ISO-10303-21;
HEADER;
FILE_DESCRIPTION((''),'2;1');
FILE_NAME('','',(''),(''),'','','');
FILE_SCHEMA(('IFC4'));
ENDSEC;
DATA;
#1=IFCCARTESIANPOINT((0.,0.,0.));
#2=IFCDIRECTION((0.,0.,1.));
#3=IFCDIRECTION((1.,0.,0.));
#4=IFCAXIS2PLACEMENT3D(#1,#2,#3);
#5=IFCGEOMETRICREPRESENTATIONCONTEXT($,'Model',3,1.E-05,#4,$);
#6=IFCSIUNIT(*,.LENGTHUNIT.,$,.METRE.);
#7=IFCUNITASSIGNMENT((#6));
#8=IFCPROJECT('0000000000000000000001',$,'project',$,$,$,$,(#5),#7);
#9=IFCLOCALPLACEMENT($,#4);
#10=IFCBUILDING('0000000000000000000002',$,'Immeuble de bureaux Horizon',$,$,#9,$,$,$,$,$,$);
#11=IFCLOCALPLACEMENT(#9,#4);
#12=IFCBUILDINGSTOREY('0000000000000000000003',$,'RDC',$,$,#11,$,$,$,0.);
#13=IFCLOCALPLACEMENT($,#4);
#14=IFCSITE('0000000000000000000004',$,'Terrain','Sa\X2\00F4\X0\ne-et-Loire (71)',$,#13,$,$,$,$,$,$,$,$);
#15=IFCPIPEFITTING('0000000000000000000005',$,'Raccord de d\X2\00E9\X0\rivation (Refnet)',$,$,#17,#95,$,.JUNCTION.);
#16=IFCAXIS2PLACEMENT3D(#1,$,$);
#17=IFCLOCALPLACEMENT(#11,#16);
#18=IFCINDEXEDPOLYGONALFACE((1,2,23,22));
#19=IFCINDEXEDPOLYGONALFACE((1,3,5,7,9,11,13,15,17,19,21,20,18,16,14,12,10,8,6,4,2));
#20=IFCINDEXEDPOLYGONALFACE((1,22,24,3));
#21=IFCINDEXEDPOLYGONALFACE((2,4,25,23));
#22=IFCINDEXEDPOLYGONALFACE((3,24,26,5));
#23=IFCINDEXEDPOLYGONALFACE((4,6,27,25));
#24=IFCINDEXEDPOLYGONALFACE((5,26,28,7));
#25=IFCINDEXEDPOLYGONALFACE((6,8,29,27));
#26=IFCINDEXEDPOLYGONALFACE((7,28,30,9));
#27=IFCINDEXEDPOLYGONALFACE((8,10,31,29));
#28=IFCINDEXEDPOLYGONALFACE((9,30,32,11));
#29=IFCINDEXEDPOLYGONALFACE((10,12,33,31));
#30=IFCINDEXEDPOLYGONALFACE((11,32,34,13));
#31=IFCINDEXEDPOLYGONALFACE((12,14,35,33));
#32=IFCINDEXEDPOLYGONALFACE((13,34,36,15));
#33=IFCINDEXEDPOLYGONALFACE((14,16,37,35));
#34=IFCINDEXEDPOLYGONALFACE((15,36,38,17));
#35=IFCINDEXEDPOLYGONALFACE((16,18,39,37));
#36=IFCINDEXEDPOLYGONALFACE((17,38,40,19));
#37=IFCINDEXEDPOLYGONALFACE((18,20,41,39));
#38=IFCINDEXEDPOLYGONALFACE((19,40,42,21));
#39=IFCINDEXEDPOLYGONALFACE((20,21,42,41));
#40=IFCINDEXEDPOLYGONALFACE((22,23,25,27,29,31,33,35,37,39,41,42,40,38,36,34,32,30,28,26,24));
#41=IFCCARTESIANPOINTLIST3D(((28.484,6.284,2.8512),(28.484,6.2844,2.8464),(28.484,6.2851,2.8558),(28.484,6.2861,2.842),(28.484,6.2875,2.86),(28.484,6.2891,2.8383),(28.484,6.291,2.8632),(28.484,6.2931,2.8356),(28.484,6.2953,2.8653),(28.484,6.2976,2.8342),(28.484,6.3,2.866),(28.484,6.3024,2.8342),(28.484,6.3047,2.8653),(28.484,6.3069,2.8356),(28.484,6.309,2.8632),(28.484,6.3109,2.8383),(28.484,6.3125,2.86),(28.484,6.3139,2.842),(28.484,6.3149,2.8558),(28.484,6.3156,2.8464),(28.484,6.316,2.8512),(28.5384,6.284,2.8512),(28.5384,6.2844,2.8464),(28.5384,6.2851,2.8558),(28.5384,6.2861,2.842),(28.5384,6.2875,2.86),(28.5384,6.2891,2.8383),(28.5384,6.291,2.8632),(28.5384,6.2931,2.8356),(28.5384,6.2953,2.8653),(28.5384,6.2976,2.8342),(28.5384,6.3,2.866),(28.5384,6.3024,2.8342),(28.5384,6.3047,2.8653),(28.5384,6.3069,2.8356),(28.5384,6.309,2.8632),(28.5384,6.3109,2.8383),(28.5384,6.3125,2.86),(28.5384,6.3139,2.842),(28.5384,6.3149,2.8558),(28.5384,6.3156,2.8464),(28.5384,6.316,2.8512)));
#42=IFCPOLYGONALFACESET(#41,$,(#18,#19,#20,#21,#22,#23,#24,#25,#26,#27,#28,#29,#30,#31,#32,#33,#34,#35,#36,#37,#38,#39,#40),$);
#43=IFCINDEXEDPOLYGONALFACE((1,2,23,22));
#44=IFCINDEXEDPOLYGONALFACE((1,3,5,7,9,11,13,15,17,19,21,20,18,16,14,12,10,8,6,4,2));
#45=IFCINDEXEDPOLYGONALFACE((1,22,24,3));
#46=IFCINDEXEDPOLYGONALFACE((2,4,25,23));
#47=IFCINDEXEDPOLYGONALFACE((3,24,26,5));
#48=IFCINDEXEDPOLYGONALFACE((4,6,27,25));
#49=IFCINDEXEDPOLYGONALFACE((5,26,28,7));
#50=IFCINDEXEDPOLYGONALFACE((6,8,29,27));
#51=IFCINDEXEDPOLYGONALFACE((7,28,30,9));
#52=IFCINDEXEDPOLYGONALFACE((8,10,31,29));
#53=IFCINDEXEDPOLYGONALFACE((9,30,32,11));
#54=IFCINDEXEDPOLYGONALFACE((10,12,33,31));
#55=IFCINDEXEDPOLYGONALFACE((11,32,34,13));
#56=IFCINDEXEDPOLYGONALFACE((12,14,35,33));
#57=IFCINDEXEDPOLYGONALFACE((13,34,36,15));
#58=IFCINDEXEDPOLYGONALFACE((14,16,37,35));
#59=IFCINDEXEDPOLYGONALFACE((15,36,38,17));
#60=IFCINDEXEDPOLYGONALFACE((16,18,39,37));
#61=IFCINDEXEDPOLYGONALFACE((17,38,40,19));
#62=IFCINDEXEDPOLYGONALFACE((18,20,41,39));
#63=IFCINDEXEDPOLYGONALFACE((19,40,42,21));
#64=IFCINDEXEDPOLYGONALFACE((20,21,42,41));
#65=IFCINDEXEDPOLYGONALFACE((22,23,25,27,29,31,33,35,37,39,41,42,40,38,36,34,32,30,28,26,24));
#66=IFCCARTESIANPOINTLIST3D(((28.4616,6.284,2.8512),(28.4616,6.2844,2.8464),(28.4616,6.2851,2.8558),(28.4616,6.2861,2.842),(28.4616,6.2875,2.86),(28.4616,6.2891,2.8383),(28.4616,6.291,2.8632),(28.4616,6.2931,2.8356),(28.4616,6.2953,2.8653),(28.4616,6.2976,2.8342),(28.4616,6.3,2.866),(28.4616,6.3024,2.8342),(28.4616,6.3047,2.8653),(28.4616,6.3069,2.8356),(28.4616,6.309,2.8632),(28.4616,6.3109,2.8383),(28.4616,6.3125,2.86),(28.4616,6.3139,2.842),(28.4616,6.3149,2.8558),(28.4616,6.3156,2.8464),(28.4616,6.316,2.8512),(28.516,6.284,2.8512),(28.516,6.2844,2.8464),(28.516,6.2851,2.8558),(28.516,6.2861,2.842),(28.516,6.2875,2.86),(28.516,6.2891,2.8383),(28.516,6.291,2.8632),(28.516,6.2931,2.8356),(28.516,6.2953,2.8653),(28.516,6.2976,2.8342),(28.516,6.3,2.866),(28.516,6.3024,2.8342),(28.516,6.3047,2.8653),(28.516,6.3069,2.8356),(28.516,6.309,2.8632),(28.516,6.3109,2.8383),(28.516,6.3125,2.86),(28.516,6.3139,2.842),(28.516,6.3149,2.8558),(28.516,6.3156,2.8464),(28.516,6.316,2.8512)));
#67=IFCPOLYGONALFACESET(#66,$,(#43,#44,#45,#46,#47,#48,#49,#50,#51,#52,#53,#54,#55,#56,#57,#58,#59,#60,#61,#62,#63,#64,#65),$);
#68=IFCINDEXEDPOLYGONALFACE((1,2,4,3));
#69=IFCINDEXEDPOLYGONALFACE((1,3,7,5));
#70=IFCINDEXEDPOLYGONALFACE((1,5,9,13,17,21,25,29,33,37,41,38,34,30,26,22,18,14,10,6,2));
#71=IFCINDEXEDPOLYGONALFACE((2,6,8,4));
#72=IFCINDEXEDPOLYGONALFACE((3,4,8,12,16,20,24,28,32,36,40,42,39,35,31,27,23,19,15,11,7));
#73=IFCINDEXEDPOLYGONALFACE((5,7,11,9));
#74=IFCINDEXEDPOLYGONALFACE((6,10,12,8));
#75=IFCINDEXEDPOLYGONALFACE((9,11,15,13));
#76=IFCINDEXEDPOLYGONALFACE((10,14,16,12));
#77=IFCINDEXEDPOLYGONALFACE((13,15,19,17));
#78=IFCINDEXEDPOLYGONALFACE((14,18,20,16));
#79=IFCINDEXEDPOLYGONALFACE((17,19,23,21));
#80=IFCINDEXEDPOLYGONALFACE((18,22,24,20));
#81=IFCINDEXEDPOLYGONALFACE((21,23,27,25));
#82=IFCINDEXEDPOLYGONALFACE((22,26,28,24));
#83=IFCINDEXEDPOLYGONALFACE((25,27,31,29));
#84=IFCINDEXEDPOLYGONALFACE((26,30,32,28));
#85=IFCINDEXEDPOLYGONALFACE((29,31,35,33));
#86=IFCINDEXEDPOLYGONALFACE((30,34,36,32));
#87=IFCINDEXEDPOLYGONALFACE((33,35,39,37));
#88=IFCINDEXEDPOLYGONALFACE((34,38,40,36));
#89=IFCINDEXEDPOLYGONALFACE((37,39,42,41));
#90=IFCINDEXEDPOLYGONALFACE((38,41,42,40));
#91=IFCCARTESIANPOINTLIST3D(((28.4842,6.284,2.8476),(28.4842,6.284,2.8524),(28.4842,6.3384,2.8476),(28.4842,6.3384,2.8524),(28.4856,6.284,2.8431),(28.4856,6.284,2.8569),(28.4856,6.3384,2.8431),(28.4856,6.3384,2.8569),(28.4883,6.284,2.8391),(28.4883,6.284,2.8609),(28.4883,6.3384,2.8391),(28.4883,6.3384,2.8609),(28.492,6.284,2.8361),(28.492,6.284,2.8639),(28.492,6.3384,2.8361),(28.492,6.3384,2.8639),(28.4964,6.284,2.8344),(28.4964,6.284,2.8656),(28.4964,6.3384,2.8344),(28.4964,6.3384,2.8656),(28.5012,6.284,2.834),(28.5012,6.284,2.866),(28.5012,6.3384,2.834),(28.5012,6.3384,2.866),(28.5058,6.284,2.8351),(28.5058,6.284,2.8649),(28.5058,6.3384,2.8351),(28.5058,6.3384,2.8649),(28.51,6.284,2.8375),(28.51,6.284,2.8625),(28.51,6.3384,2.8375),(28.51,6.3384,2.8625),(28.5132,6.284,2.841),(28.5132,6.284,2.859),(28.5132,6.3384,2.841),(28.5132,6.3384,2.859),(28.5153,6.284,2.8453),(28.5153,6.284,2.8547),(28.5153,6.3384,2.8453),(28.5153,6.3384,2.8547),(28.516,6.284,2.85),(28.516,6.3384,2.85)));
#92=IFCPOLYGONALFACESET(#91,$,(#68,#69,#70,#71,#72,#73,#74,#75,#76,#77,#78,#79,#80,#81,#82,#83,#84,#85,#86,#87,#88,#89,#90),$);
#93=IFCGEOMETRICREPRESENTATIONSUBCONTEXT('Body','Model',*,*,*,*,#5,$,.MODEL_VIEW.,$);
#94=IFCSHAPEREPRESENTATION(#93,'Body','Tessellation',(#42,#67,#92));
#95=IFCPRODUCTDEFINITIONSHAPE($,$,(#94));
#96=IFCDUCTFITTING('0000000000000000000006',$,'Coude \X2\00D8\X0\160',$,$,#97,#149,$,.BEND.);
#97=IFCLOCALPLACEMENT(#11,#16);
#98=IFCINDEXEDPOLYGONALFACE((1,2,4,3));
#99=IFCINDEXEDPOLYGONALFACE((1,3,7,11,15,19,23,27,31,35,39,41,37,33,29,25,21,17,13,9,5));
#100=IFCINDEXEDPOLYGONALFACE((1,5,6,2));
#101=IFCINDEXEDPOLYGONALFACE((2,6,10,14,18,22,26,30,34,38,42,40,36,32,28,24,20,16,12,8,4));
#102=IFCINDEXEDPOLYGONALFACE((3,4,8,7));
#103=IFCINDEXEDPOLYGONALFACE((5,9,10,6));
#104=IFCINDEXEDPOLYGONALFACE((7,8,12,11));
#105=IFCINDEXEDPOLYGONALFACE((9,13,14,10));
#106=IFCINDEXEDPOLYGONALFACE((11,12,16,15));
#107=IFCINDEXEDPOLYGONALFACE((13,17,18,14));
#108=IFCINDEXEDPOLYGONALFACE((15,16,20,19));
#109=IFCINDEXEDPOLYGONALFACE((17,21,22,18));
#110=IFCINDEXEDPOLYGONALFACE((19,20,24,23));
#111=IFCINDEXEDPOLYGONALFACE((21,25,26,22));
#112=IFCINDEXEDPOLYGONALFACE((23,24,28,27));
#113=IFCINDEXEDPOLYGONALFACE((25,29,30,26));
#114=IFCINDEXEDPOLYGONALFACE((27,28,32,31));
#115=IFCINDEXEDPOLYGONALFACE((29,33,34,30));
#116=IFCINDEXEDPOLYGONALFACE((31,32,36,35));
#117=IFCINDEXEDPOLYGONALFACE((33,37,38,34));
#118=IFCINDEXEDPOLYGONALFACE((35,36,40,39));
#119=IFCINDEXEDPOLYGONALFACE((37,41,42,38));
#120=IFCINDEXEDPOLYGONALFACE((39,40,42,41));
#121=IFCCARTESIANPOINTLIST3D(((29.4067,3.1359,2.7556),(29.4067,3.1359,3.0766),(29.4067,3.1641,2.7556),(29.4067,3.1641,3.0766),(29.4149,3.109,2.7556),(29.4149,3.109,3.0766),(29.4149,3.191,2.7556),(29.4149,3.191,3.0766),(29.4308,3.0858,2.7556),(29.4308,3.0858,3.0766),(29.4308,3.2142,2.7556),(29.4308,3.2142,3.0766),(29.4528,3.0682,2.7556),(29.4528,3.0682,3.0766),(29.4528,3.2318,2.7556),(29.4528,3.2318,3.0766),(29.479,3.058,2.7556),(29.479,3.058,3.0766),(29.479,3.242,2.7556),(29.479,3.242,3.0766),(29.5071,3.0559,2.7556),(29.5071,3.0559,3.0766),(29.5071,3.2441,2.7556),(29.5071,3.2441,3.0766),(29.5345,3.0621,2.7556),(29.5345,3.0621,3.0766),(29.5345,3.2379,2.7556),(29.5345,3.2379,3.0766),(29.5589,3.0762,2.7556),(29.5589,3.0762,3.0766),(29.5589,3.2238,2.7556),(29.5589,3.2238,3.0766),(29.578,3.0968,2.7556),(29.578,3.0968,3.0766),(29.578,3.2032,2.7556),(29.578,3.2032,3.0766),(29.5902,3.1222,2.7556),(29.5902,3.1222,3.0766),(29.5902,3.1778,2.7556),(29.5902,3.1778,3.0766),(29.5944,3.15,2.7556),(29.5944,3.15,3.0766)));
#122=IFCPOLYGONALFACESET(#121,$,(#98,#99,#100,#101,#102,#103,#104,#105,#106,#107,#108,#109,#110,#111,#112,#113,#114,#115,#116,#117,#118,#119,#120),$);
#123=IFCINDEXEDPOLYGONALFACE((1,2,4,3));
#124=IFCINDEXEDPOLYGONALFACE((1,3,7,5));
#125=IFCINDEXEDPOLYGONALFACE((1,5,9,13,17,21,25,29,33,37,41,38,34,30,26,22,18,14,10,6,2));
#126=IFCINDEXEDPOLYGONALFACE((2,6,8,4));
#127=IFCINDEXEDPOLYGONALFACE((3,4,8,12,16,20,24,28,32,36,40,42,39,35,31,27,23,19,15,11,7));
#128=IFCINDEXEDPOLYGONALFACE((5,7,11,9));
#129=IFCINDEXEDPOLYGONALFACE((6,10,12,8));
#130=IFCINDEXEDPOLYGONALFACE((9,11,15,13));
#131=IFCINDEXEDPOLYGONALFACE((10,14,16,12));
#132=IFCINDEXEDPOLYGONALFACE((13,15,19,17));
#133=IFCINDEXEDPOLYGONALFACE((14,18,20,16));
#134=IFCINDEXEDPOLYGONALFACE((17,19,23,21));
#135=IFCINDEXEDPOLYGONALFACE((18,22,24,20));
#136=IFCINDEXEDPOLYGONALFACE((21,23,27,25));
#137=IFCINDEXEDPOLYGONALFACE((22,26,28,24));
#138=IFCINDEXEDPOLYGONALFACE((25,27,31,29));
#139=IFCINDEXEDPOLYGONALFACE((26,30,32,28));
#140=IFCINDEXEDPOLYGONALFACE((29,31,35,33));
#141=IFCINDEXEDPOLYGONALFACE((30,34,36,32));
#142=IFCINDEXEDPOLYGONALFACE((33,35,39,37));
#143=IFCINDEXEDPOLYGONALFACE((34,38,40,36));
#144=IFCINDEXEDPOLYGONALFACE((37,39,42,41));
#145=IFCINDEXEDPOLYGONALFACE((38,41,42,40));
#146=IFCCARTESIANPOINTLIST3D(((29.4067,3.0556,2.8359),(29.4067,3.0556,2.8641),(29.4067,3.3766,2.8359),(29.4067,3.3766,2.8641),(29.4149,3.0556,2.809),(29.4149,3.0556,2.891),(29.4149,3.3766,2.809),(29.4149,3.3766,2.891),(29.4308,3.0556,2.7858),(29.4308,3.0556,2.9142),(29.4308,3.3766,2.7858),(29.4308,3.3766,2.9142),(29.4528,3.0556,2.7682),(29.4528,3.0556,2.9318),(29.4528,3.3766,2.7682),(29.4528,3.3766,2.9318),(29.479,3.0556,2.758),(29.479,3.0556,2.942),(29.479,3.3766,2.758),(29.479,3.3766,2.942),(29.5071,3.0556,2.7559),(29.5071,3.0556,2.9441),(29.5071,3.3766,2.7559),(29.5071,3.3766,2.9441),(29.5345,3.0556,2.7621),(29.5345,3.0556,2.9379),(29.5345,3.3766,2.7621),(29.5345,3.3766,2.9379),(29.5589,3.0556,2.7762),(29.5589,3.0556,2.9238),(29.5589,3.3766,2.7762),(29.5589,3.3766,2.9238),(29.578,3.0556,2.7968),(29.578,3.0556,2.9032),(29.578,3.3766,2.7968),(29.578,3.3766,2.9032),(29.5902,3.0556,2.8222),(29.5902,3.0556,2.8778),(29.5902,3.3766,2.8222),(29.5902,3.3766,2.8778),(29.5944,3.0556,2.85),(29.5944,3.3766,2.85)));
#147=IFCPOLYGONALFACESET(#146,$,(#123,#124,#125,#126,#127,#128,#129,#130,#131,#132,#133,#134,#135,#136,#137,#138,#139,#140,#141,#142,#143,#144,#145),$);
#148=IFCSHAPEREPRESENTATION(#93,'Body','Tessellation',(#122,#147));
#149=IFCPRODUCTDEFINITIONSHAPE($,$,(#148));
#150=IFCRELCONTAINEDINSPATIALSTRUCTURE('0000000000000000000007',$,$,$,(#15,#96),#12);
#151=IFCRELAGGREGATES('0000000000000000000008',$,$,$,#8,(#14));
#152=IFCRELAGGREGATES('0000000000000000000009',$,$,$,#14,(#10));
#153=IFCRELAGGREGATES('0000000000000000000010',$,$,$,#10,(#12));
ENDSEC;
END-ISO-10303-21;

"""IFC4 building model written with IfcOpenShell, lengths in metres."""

from ifc_helpers import new_model, si_unit, frame, origin_with_axes, place, context, subcontext, project, spatial, circle, extrude, element, save


model = new_model("IFC4")

# Units and contexts
model_context = context("Model", 3, precision=1e-05, world=origin_with_axes())
body_context = subcontext(model_context, "Body", "Model", "MODEL_VIEW")
ifc_project = project(units=[si_unit("LENGTHUNIT", "METRE")], contexts=[model_context])

# Site, building, storey
site_placement = place(None, origin_with_axes())
site = spatial("IfcSite", under=ifc_project, at=site_placement, Name="Terrain", Description="Saône-et-Loire (71)")
building_placement = place(None, origin_with_axes())
building = spatial("IfcBuilding", under=site, at=building_placement, Name="Immeuble de bureaux Horizon")
storey_placement = place(building_placement, origin_with_axes())
storey = spatial("IfcBuildingStorey", under=building, at=storey_placement, Name="RDC", Elevation=0.0)

# Pipe fitting
pipe_fitting_1_placement = place(storey_placement, frame((28.5, 6.3, 2.85), z_axis=(0.0, 0.0, 1.0), x_axis=(1.0, 0.0, 0.0)))
element("IfcPipeFitting", 1, at=pipe_fitting_1_placement, inside=storey, Name="Raccord de dérivation (Refnet)", PredefinedType="JUNCTION", context=body_context, shape_type="SweptSolid", body=[
    extrude(circle(Radius=0.016), frame((-0.016, 0.0, 0.0), z_axis=(1.0, 0.0, 0.0), x_axis=(0.0, 0.0, 1.0)), (0.0, 0.0, 1.0), 0.0544),
    extrude(circle(Radius=0.016), frame((0.016, 0.0, 0.0), z_axis=(-1.0, 0.0, 0.0), x_axis=(0.0, 0.0, 1.0)), (0.0, 0.0, 1.0), 0.0544),
    extrude(circle(Radius=0.016), frame((0.0, -0.016, 0.0), z_axis=(0.0, 1.0, 0.0), x_axis=(1.0, 0.0, 0.0)), (0.0, 0.0, 1.0), 0.0544),
])

# Duct fitting
duct_fitting_placement = place(storey_placement, frame((29.5, 3.15, 2.85), z_axis=(0.0, 0.0, 1.0), x_axis=(1.0, 0.0, 0.0)))
element("IfcDuctFitting", 2, at=duct_fitting_placement, inside=storey, Name="Coude Ø160", PredefinedType="BEND", context=body_context, shape_type="SweptSolid", body=[
    extrude(circle(Radius=0.0944), frame((0.0, 0.0, -0.0944), z_axis=(0.0, 0.0, 1.0), x_axis=(1.0, 0.0, 0.0)), (0.0, 0.0, 1.0), 0.321),
    extrude(circle(Radius=0.0944), frame((0.0, -0.0944, 0.0), z_axis=(0.0, 1.0, 0.0), x_axis=(1.0, 0.0, 0.0)), (0.0, 0.0, 1.0), 0.321),
])

save(model, "model.ifc")
